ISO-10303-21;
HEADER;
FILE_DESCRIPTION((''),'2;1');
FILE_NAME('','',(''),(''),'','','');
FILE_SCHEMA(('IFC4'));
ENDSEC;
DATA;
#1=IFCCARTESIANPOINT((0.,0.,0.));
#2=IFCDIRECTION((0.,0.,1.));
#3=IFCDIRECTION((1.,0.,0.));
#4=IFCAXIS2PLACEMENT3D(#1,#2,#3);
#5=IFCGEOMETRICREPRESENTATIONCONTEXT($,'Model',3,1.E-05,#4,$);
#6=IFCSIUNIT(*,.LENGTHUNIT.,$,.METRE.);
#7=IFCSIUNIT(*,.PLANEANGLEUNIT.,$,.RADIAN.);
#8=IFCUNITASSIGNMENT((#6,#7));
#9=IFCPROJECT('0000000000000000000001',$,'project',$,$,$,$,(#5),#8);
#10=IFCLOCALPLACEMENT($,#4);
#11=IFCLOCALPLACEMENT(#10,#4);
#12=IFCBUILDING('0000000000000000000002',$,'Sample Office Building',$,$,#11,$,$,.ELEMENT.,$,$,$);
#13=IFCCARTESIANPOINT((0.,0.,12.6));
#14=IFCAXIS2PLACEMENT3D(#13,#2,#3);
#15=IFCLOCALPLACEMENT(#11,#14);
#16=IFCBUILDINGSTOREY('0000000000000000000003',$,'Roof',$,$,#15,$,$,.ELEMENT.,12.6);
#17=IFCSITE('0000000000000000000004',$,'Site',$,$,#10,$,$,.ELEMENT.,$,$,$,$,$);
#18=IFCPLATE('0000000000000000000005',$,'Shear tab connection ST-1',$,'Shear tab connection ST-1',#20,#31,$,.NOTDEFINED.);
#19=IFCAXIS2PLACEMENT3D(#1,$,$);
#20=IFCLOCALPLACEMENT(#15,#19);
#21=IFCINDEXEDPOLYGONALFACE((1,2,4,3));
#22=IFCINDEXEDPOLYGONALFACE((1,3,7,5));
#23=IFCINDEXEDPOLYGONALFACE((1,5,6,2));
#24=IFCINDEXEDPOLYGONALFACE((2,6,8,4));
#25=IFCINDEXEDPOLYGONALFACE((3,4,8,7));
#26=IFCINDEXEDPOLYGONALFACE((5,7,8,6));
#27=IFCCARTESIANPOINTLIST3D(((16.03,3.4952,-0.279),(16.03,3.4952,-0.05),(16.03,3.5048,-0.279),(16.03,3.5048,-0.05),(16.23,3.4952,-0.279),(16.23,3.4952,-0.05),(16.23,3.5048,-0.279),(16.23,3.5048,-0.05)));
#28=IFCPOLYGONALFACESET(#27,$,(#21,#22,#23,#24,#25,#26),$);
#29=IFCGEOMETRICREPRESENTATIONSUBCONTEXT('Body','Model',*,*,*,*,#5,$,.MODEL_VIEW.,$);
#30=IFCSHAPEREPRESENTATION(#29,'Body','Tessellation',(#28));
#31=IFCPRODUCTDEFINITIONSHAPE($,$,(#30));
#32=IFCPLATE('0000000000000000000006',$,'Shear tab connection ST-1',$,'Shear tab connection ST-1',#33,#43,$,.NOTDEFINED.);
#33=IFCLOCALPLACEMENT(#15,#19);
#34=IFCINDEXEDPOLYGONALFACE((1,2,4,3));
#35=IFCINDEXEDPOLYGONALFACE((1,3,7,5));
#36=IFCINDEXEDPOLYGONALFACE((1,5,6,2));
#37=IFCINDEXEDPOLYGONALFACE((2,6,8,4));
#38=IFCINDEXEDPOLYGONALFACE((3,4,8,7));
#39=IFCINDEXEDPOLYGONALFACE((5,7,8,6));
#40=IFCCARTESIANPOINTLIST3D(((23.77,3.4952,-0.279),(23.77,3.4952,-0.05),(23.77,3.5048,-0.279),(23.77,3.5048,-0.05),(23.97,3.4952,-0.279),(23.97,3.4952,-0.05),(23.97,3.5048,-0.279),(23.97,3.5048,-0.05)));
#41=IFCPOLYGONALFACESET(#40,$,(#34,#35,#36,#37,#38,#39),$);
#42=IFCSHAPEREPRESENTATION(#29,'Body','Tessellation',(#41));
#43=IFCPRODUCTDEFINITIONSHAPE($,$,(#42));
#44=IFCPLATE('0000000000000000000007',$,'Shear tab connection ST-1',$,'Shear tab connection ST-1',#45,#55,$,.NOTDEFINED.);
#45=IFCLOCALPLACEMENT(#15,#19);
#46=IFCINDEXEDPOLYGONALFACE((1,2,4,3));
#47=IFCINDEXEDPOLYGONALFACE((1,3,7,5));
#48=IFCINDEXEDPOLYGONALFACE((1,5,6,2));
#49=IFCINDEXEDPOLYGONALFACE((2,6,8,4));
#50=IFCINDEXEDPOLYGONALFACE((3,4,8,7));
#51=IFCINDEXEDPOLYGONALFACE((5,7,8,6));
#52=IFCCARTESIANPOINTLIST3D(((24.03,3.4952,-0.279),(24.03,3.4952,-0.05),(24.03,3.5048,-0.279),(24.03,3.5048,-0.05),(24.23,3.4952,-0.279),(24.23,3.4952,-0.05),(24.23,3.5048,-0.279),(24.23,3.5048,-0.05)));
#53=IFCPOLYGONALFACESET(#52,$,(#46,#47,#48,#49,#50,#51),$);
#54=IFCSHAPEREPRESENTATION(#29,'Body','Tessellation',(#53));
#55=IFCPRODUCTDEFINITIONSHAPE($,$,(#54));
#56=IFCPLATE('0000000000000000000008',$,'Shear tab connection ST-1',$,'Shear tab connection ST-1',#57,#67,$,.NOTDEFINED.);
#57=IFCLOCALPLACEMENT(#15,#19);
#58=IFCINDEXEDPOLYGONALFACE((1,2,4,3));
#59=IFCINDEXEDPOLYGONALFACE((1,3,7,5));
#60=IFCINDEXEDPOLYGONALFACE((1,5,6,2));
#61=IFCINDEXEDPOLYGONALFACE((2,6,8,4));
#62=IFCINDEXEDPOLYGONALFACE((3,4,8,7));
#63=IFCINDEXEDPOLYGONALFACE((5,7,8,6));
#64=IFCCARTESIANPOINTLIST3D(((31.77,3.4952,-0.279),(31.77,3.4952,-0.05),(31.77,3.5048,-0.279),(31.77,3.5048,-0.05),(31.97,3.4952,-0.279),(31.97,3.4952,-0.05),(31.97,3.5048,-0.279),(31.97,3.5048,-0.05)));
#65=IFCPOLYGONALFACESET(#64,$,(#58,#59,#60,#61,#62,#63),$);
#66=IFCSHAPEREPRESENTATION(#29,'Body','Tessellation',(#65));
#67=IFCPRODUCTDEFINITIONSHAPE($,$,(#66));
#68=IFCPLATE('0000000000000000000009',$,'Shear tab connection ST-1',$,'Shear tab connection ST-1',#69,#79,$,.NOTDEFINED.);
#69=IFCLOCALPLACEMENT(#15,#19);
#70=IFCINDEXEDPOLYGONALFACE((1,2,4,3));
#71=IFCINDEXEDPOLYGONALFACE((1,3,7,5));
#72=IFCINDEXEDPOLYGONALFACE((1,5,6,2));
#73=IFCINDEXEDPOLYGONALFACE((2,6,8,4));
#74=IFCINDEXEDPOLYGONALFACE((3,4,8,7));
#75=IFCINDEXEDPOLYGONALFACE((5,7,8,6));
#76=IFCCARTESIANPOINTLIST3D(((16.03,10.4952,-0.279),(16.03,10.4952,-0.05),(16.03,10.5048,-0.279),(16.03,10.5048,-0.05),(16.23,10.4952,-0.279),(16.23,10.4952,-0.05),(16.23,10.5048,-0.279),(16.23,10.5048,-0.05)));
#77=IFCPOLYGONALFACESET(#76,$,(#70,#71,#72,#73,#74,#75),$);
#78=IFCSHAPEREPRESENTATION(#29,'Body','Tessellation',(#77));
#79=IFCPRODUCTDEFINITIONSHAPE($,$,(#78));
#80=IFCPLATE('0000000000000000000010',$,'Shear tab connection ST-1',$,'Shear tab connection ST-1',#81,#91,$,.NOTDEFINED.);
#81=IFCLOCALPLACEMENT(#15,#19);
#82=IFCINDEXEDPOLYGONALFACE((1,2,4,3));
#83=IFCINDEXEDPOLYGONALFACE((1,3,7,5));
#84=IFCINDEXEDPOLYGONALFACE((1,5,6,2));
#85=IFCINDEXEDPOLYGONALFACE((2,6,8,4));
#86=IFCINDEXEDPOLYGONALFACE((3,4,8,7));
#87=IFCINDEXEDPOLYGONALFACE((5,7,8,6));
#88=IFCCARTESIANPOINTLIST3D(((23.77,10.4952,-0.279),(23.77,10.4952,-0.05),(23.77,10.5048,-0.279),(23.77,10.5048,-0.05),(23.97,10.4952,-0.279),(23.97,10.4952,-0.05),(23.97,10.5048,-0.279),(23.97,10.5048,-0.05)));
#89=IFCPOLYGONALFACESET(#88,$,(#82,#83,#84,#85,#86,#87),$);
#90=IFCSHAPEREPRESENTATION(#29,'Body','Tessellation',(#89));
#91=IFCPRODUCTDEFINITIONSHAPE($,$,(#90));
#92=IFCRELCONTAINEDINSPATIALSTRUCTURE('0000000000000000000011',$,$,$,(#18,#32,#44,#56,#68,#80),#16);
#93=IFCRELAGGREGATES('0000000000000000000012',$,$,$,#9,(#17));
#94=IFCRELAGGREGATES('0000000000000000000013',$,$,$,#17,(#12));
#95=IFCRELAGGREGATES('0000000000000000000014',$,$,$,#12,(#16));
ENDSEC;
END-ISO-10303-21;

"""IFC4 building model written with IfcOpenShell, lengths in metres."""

from ifc_helpers import new_model, si_unit, frame, origin_with_axes, place, context, subcontext, project, spatial, rectangle, extrude, element, save


model = new_model("IFC4")

# Units and contexts
model_context = context("Model", 3, precision=1e-05, world=origin_with_axes())
body_context = subcontext(model_context, "Body", "Model", "MODEL_VIEW")
ifc_project = project(units=[si_unit("LENGTHUNIT", "METRE"), si_unit("PLANEANGLEUNIT", "RADIAN")], contexts=[model_context])

# Site, building, storey
site_placement = place(None, origin_with_axes())
site = spatial("IfcSite", under=ifc_project, at=site_placement, Name="Site", CompositionType="ELEMENT")
building_placement = place(site_placement, origin_with_axes())
building = spatial("IfcBuilding", under=site, at=building_placement, Name="Sample Office Building", CompositionType="ELEMENT")
storey_placement = place(building_placement, frame((0.0, 0.0, 12.6), z_axis=(0.0, 0.0, 1.0), x_axis=(1.0, 0.0, 0.0)))
storey = spatial("IfcBuildingStorey", under=building, at=storey_placement, Name="Roof", CompositionType="ELEMENT", Elevation=12.6)

# Plates
for number, where, z_axis, x_axis, name in (
    (1, (16.13, 3.5, 12.321), (0.0, 0.0, 1.0), (1.0, 0.0, 0.0), "Shear tab connection ST-1"),
    (2, (23.87, 3.5, 12.321), (0.0, 0.0, 1.0), (1.0, 0.0, 0.0), "Shear tab connection ST-1"),
    (3, (24.13, 3.5, 12.321), (0.0, 0.0, 1.0), (1.0, 0.0, 0.0), "Shear tab connection ST-1"),
    (4, (31.87, 3.5, 12.321), (0.0, 0.0, 1.0), (1.0, 0.0, 0.0), "Shear tab connection ST-1"),
):
    element("IfcPlate", number, at=place(None, frame(where, z_axis=z_axis, x_axis=x_axis)), inside=storey, Name=name, ObjectType="Shear tab connection ST-1", PredefinedType="NOTDEFINED", context=body_context, shape_type="SweptSolid", body=[
        extrude(rectangle(XDim=0.2, YDim=0.0095), None, (0.0, 0.0, 1.0), 0.229),
    ])
for number, where, z_axis, x_axis, name in (
    (5, (16.13, 10.5, 12.321), (0.0, 0.0, 1.0), (1.0, 0.0, 0.0), "Shear tab connection ST-1"),
    (6, (23.87, 10.5, 12.321), (0.0, 0.0, 1.0), (1.0, 0.0, 0.0), "Shear tab connection ST-1"),
):
    element("IfcPlate", number, at=place(None, frame(where, z_axis=z_axis, x_axis=x_axis)), inside=storey, Name=name, ObjectType="Shear tab connection ST-1", PredefinedType="NOTDEFINED", context=body_context, shape_type="SweptSolid", body=[
        extrude(rectangle(XDim=0.2, YDim=0.0095), None, (0.0, 0.0, 1.0), 0.229),
    ])

save(model, "model.ifc")
